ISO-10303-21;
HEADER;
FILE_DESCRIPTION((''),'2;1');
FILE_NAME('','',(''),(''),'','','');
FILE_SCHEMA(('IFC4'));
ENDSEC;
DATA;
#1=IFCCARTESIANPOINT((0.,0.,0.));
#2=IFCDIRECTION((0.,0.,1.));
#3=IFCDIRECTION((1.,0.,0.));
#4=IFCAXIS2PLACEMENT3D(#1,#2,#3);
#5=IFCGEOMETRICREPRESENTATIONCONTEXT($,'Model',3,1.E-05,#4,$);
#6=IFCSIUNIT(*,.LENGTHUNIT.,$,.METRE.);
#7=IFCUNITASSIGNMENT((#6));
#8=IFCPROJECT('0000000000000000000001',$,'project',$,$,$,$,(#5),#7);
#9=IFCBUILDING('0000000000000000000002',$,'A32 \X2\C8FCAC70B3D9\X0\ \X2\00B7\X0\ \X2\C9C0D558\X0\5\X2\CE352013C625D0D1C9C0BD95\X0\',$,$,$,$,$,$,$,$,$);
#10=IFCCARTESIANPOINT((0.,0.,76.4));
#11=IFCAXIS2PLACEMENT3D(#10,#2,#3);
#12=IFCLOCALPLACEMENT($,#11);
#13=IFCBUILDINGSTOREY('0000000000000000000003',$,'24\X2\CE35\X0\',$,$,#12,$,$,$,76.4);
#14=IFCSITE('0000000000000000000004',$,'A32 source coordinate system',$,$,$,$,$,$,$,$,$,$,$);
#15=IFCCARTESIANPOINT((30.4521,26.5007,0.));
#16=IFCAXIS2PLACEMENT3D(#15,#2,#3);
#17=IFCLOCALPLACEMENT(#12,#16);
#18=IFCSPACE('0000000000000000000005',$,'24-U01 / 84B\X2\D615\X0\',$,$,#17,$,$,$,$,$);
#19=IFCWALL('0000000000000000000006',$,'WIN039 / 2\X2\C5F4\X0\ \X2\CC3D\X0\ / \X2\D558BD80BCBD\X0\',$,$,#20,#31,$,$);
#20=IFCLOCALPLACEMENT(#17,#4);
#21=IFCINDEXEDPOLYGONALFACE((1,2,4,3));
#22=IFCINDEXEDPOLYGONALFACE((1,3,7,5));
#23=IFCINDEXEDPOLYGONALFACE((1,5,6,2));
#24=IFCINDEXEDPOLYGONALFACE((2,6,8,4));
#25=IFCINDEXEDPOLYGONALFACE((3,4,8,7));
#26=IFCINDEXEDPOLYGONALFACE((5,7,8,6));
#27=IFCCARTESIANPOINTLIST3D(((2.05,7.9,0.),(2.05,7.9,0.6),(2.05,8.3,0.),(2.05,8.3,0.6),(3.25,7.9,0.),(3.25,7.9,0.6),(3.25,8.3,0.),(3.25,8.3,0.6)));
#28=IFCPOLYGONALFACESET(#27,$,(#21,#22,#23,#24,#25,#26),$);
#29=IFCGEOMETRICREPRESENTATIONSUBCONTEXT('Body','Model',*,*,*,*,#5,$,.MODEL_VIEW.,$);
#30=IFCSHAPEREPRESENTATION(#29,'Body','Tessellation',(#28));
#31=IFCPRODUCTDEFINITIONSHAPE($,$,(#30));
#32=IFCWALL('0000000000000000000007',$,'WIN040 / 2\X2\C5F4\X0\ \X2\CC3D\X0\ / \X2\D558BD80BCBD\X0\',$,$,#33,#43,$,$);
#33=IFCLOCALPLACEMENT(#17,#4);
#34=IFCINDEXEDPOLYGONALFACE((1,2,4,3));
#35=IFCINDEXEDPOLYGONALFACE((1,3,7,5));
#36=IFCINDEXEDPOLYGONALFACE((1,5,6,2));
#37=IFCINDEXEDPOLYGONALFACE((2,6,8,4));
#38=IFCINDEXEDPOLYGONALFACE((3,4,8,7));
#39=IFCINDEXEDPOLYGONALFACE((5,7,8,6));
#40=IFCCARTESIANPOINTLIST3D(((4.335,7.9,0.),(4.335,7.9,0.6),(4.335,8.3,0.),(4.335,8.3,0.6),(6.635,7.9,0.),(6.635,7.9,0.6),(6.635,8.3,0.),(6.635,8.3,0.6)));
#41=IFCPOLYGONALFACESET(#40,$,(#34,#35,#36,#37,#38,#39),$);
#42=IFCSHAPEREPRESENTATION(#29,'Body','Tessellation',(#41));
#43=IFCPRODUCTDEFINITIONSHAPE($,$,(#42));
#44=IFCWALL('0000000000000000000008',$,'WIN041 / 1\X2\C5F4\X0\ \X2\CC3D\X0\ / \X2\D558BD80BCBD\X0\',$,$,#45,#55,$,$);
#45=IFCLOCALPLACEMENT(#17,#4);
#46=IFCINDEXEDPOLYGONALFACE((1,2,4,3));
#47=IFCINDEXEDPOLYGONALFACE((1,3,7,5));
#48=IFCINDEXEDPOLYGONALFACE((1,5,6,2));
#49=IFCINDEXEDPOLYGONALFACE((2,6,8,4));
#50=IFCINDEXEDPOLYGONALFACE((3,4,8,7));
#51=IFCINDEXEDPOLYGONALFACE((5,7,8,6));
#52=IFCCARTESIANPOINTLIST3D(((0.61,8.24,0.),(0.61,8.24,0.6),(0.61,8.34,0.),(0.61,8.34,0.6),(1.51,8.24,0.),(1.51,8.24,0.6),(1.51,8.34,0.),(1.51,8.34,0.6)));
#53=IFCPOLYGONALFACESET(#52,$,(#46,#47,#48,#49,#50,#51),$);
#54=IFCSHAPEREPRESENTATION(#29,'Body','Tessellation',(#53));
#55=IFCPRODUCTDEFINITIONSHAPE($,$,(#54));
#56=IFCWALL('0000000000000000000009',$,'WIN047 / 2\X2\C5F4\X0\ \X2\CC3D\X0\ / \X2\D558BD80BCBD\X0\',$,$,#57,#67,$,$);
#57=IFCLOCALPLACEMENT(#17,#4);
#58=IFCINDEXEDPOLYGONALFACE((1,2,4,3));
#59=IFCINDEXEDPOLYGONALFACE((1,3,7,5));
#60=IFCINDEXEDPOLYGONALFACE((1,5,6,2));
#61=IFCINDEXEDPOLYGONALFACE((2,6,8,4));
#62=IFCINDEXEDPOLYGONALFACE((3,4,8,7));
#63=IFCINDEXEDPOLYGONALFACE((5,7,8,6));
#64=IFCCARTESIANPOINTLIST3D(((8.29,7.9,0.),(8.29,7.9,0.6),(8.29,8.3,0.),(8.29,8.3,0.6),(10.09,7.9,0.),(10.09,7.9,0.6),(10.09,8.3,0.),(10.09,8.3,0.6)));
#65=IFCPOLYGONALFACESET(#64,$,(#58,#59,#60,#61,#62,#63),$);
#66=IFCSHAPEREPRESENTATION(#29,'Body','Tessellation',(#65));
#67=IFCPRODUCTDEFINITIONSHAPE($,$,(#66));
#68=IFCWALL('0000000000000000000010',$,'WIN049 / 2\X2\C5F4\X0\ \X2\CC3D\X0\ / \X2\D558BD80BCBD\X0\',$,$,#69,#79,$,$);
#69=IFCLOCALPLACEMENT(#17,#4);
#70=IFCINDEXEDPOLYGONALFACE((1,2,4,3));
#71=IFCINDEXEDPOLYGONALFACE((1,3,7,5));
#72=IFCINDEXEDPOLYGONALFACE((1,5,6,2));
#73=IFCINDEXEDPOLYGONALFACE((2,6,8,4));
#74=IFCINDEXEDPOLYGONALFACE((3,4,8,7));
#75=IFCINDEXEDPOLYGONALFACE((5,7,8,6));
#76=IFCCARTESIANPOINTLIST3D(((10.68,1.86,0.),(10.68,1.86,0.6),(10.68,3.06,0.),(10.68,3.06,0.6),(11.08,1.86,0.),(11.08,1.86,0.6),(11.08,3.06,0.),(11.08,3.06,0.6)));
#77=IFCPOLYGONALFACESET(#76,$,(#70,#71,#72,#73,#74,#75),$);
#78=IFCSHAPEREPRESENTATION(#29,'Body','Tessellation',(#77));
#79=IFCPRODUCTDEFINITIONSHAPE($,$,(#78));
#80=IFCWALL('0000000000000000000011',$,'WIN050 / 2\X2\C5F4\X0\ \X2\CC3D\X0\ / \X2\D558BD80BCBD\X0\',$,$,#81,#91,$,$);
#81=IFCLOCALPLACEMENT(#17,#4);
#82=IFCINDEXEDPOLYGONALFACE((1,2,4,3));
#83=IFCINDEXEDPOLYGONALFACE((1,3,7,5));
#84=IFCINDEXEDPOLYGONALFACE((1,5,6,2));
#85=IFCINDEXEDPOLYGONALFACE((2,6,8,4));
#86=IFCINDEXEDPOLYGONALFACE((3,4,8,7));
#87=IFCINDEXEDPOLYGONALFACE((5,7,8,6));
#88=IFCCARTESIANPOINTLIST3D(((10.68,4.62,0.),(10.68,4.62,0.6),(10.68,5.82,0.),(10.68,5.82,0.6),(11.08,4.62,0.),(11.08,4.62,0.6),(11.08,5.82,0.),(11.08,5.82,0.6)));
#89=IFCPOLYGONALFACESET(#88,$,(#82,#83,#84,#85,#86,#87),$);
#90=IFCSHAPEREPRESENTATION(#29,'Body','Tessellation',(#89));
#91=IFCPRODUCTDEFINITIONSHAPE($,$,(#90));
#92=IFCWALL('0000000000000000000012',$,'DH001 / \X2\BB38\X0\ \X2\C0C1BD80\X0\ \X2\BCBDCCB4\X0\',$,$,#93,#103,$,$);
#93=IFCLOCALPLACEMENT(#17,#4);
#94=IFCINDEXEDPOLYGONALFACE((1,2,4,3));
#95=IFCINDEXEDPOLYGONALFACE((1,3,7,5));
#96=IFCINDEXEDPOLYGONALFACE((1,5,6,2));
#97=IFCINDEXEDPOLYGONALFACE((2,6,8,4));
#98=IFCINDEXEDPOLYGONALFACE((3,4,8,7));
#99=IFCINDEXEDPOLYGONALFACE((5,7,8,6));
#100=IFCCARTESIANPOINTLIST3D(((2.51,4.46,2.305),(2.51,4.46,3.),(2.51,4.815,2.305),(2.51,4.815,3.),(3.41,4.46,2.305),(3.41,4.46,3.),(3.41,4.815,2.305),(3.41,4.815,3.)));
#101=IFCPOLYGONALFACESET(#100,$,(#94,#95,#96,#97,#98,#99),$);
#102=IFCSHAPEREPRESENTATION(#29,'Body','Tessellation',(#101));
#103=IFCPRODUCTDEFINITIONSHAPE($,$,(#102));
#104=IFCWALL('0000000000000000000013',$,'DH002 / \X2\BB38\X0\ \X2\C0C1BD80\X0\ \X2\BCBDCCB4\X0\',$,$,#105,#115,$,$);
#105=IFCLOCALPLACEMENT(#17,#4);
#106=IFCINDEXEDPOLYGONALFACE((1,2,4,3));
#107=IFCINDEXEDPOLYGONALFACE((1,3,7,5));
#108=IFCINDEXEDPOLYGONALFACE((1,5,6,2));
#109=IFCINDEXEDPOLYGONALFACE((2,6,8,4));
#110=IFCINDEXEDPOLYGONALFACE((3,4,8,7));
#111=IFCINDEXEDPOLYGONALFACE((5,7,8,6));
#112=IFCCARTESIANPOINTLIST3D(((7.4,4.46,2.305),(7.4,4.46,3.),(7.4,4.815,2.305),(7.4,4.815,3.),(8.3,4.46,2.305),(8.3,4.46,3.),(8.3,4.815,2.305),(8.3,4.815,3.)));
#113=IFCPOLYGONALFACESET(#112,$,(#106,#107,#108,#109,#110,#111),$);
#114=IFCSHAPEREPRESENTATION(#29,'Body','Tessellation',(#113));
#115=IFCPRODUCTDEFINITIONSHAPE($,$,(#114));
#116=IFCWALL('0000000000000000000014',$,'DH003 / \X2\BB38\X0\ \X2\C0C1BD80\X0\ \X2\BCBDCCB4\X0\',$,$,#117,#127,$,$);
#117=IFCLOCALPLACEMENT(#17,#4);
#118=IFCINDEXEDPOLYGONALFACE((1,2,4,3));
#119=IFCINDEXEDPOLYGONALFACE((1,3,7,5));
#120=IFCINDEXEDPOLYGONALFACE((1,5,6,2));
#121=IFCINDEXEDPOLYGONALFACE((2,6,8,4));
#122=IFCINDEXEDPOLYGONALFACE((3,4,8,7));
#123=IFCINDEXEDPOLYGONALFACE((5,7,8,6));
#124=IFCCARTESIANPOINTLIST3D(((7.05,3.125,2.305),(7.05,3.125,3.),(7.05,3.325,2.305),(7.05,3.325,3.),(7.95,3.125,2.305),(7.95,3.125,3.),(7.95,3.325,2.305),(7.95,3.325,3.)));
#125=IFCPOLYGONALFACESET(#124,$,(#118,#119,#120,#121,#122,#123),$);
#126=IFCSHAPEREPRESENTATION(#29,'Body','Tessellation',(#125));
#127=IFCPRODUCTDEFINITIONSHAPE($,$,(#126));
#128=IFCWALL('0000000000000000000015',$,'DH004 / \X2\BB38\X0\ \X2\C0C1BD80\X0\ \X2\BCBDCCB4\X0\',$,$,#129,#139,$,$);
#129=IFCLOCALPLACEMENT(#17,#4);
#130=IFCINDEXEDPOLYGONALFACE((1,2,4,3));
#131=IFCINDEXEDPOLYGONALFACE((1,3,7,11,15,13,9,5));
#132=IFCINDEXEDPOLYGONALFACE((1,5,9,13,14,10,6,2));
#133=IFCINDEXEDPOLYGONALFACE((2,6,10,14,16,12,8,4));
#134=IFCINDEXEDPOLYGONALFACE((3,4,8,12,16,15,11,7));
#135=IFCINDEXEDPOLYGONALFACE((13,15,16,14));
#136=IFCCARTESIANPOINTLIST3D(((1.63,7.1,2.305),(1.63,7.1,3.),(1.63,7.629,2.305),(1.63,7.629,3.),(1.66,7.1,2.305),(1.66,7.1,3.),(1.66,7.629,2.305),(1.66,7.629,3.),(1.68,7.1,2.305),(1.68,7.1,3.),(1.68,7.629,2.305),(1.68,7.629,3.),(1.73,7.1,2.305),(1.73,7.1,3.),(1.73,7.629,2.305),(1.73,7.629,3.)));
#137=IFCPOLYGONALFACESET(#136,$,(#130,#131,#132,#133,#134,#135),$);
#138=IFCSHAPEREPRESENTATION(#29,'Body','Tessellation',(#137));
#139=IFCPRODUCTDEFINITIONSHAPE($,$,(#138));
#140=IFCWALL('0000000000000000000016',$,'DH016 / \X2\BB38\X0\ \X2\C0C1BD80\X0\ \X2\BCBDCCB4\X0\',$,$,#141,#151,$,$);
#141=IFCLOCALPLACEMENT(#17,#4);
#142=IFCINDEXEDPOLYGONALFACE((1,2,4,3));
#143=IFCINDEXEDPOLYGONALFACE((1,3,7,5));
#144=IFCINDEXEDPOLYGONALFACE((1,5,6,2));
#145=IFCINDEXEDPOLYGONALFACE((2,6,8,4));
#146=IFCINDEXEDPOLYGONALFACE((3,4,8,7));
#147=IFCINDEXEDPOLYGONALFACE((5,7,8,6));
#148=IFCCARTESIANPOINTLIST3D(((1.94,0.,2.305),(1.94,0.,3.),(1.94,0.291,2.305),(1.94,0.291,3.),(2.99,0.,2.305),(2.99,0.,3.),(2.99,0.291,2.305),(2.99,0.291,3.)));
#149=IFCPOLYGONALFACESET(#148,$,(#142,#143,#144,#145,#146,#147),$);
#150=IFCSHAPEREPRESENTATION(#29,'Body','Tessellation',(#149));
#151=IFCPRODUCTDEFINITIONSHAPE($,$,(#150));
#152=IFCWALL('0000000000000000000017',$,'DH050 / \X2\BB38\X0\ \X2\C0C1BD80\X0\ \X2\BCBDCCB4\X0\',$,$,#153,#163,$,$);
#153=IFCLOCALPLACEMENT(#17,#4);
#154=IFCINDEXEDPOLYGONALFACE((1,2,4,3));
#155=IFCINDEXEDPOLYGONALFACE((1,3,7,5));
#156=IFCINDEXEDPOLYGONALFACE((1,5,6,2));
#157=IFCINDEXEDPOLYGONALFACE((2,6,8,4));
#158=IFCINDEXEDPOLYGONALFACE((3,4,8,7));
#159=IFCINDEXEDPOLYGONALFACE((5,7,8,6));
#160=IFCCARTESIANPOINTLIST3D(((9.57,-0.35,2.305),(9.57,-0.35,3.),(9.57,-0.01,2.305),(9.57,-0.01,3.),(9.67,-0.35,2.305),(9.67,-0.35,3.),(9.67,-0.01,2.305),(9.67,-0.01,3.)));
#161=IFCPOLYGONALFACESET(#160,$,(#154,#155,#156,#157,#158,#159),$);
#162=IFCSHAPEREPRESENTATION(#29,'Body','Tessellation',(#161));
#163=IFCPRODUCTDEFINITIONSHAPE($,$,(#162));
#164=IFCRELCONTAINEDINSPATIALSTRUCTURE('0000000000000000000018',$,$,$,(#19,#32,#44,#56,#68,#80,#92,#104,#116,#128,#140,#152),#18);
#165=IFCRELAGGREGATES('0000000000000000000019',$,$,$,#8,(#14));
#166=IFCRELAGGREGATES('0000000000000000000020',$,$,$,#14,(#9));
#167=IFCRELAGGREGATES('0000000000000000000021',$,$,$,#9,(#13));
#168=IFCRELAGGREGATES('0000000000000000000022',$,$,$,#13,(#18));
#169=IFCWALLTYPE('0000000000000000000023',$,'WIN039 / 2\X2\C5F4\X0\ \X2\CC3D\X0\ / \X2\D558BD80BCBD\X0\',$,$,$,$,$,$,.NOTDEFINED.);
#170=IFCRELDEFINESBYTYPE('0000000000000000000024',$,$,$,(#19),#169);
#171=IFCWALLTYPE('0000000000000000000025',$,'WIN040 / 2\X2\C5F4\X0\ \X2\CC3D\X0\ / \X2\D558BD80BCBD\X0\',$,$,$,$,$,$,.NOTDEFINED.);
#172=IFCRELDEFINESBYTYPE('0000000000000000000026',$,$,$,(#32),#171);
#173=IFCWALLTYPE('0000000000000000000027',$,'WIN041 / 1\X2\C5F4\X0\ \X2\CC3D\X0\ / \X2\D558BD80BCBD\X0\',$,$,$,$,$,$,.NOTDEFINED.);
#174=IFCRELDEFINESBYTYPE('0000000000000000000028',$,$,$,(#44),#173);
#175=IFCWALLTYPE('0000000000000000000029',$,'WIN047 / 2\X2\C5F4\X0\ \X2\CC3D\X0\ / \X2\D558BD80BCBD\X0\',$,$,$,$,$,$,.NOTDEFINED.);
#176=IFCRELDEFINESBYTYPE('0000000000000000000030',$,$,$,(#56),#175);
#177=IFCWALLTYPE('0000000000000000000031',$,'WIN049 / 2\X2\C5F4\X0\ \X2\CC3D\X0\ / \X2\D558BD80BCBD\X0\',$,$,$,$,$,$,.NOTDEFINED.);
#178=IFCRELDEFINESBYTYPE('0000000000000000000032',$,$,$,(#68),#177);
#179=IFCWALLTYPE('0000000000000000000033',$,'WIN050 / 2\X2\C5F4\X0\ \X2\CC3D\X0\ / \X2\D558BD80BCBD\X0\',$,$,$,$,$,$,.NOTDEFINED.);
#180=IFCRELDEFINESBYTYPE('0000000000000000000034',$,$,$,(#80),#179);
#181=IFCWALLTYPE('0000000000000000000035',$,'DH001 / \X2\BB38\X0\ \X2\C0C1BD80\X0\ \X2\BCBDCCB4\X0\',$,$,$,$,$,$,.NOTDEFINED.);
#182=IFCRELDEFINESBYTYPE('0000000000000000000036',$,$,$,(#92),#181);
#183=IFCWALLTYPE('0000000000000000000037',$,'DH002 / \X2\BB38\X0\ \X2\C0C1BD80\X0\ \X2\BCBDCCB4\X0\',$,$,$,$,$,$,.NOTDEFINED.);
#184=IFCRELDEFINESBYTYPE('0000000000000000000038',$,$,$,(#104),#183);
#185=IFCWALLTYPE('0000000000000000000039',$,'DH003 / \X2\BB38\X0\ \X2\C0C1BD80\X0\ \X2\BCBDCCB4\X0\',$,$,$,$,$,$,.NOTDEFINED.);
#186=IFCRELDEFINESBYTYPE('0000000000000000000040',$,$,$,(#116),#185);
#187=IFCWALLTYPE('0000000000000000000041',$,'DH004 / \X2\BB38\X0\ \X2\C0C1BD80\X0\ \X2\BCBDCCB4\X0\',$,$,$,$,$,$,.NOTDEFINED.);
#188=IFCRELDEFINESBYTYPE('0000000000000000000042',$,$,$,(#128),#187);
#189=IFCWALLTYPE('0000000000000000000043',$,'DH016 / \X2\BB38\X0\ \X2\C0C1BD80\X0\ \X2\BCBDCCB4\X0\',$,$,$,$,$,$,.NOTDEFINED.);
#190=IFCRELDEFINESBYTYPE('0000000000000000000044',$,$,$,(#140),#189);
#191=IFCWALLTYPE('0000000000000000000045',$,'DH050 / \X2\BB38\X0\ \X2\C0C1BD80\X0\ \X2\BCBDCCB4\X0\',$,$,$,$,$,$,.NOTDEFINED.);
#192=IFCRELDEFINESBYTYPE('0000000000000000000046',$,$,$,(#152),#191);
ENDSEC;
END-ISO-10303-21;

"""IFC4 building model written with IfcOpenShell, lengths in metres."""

from ifc_helpers import new_model, si_unit, frame, origin, origin_with_axes, place, context, subcontext, project, spatial, polyline, outline, extrude, source, transform, mapped, type_object, type_shapes, element, save


model = new_model("IFC4")

# Units and contexts
model_context = context("Model", 3, precision=1e-05, world=origin_with_axes())
body_context = subcontext(model_context, "Body", "Model", "MODEL_VIEW")
ifc_project = project(units=[si_unit("LENGTHUNIT", "METRE")], contexts=[model_context])

# Site, building, storey, space
site = spatial("IfcSite", under=ifc_project, Name="A32 source coordinate system")
building = spatial("IfcBuilding", under=site, Name="A32 주거동 · 지하5층–옥탑지붕")
storey_placement = place(None, frame((0.0, 0.0, 76.4), z_axis=(0.0, 0.0, 1.0), x_axis=(1.0, 0.0, 0.0)))
storey = spatial("IfcBuildingStorey", under=building, at=storey_placement, Name="24층", Elevation=76.4)
space_placement = place(storey_placement, frame((30.4521, 26.5007, 0.0), z_axis=(0.0, 0.0, 1.0), x_axis=(1.0, 0.0, 0.0)))
space = spatial("IfcSpace", under=storey, at=space_placement, Name="24-U01 / 84B형")

# Walls
wall_type_1 = type_object("IfcWallType", Name="WIN039 / 2열 창 / 하부벽", PredefinedType="NOTDEFINED")
shared_shape_1 = source(origin(), body_context, "Body", "SweptSolid", [
    extrude(outline(polyline([(2.05, 8.3), (3.25, 8.3), (3.25, 7.9), (2.05, 7.9), (2.05, 8.3)])), origin(), (0.0, 0.0, 1.0), 0.6),
])
type_shapes(wall_type_1, [shared_shape_1])
wall_1_placement = place(space_placement, origin_with_axes())
element("IfcWall", 1, at=wall_1_placement, inside=space, type_object=wall_type_1, Name="WIN039 / 2열 창 / 하부벽", context=body_context, shape_type="MappedRepresentation", body=[
    mapped(shared_shape_1, transform((0.0, 0.0, 0.0), scale=1.0)),
])
wall_type_2 = type_object("IfcWallType", Name="WIN040 / 2열 창 / 하부벽", PredefinedType="NOTDEFINED")
shared_shape_2 = source(origin(), body_context, "Body", "SweptSolid", [
    extrude(outline(polyline([(4.335, 8.3), (6.635, 8.3), (6.635, 7.9), (4.335, 7.9), (4.335, 8.3)])), origin(), (0.0, 0.0, 1.0), 0.6),
])
type_shapes(wall_type_2, [shared_shape_2])
wall_2_placement = place(space_placement, origin_with_axes())
element("IfcWall", 2, at=wall_2_placement, inside=space, type_object=wall_type_2, Name="WIN040 / 2열 창 / 하부벽", context=body_context, shape_type="MappedRepresentation", body=[
    mapped(shared_shape_2, transform((0.0, 0.0, 0.0), scale=1.0)),
])
wall_type_3 = type_object("IfcWallType", Name="WIN041 / 1열 창 / 하부벽", PredefinedType="NOTDEFINED")
shared_shape_3 = source(origin(), body_context, "Body", "SweptSolid", [
    extrude(outline(polyline([(0.61, 8.34), (1.51, 8.34), (1.51, 8.24), (0.61, 8.24), (0.61, 8.34)])), origin(), (0.0, 0.0, 1.0), 0.6),
])
type_shapes(wall_type_3, [shared_shape_3])
wall_3_placement = place(space_placement, origin_with_axes())
element("IfcWall", 3, at=wall_3_placement, inside=space, type_object=wall_type_3, Name="WIN041 / 1열 창 / 하부벽", context=body_context, shape_type="MappedRepresentation", body=[
    mapped(shared_shape_3, transform((0.0, 0.0, 0.0), scale=1.0)),
])
wall_type_4 = type_object("IfcWallType", Name="WIN047 / 2열 창 / 하부벽", PredefinedType="NOTDEFINED")
shared_shape_4 = source(origin(), body_context, "Body", "SweptSolid", [
    extrude(outline(polyline([(8.29, 8.3), (10.09, 8.3), (10.09, 7.9), (8.29, 7.9), (8.29, 8.3)])), origin(), (0.0, 0.0, 1.0), 0.6),
])
type_shapes(wall_type_4, [shared_shape_4])
wall_4_placement = place(space_placement, origin_with_axes())
element("IfcWall", 4, at=wall_4_placement, inside=space, type_object=wall_type_4, Name="WIN047 / 2열 창 / 하부벽", context=body_context, shape_type="MappedRepresentation", body=[
    mapped(shared_shape_4, transform((0.0, 0.0, 0.0), scale=1.0)),
])
wall_type_5 = type_object("IfcWallType", Name="WIN049 / 2열 창 / 하부벽", PredefinedType="NOTDEFINED")
shared_shape_5 = source(origin(), body_context, "Body", "SweptSolid", [
    extrude(outline(polyline([(10.68, 3.06), (11.08, 3.06), (11.08, 1.86), (10.68, 1.86), (10.68, 3.06)])), origin(), (0.0, 0.0, 1.0), 0.6),
])
type_shapes(wall_type_5, [shared_shape_5])
wall_5_placement = place(space_placement, origin_with_axes())
element("IfcWall", 5, at=wall_5_placement, inside=space, type_object=wall_type_5, Name="WIN049 / 2열 창 / 하부벽", context=body_context, shape_type="MappedRepresentation", body=[
    mapped(shared_shape_5, transform((0.0, 0.0, 0.0), scale=1.0)),
])
wall_type_6 = type_object("IfcWallType", Name="WIN050 / 2열 창 / 하부벽", PredefinedType="NOTDEFINED")
shared_shape_6 = source(origin(), body_context, "Body", "SweptSolid", [
    extrude(outline(polyline([(10.68, 5.82), (11.08, 5.82), (11.08, 4.62), (10.68, 4.62), (10.68, 5.82)])), origin(), (0.0, 0.0, 1.0), 0.6),
])
type_shapes(wall_type_6, [shared_shape_6])
wall_6_placement = place(space_placement, origin_with_axes())
element("IfcWall", 6, at=wall_6_placement, inside=space, type_object=wall_type_6, Name="WIN050 / 2열 창 / 하부벽", context=body_context, shape_type="MappedRepresentation", body=[
    mapped(shared_shape_6, transform((0.0, 0.0, 0.0), scale=1.0)),
])
wall_type_7 = type_object("IfcWallType", Name="DH001 / 문 상부 벽체", PredefinedType="NOTDEFINED")
shared_shape_7 = source(origin(), body_context, "Body", "SweptSolid", [
    extrude(outline(polyline([(3.41, 4.815), (3.41, 4.46), (2.51, 4.46), (2.51, 4.815), (3.41, 4.815)])), frame((0.0, 0.0, 2.305)), (0.0, 0.0, 1.0), 0.695),
])
type_shapes(wall_type_7, [shared_shape_7])
wall_7_placement = place(space_placement, origin_with_axes())
element("IfcWall", 7, at=wall_7_placement, inside=space, type_object=wall_type_7, Name="DH001 / 문 상부 벽체", context=body_context, shape_type="MappedRepresentation", body=[
    mapped(shared_shape_7, transform((0.0, 0.0, 0.0), scale=1.0)),
])
wall_type_8 = type_object("IfcWallType", Name="DH002 / 문 상부 벽체", PredefinedType="NOTDEFINED")
shared_shape_8 = source(origin(), body_context, "Body", "SweptSolid", [
    extrude(outline(polyline([(8.3, 4.815), (8.3, 4.46), (7.4, 4.46), (7.4, 4.815), (8.3, 4.815)])), frame((0.0, 0.0, 2.305)), (0.0, 0.0, 1.0), 0.695),
])
type_shapes(wall_type_8, [shared_shape_8])
wall_8_placement = place(space_placement, origin_with_axes())
element("IfcWall", 8, at=wall_8_placement, inside=space, type_object=wall_type_8, Name="DH002 / 문 상부 벽체", context=body_context, shape_type="MappedRepresentation", body=[
    mapped(shared_shape_8, transform((0.0, 0.0, 0.0), scale=1.0)),
])
wall_type_9 = type_object("IfcWallType", Name="DH003 / 문 상부 벽체", PredefinedType="NOTDEFINED")
shared_shape_9 = source(origin(), body_context, "Body", "SweptSolid", [
    extrude(outline(polyline([(7.95, 3.325), (7.95, 3.125), (7.05, 3.125), (7.05, 3.325), (7.95, 3.325)])), frame((0.0, 0.0, 2.305)), (0.0, 0.0, 1.0), 0.695),
])
type_shapes(wall_type_9, [shared_shape_9])
wall_9_placement = place(space_placement, origin_with_axes())
element("IfcWall", 9, at=wall_9_placement, inside=space, type_object=wall_type_9, Name="DH003 / 문 상부 벽체", context=body_context, shape_type="MappedRepresentation", body=[
    mapped(shared_shape_9, transform((0.0, 0.0, 0.0), scale=1.0)),
])
wall_type_10 = type_object("IfcWallType", Name="DH004 / 문 상부 벽체", PredefinedType="NOTDEFINED")
shared_shape_10 = source(origin(), body_context, "Body", "SweptSolid", [
    extrude(outline(polyline([(1.66, 7.1), (1.63, 7.1), (1.63, 7.629), (1.66, 7.629), (1.68, 7.629), (1.73, 7.629), (1.73, 7.1), (1.68, 7.1), (1.66, 7.1)])), frame((0.0, 0.0, 2.305)), (0.0, 0.0, 1.0), 0.695),
])
type_shapes(wall_type_10, [shared_shape_10])
wall_10_placement = place(space_placement, origin_with_axes())
element("IfcWall", 10, at=wall_10_placement, inside=space, type_object=wall_type_10, Name="DH004 / 문 상부 벽체", context=body_context, shape_type="MappedRepresentation", body=[
    mapped(shared_shape_10, transform((0.0, 0.0, 0.0), scale=1.0)),
])
wall_type_11 = type_object("IfcWallType", Name="DH016 / 문 상부 벽체", PredefinedType="NOTDEFINED")
shared_shape_11 = source(origin(), body_context, "Body", "SweptSolid", [
    extrude(outline(polyline([(2.99, 0.291), (2.99, 0.0), (1.94, 0.0), (1.94, 0.291), (2.99, 0.291)])), frame((0.0, 0.0, 2.305)), (0.0, 0.0, 1.0), 0.695),
])
type_shapes(wall_type_11, [shared_shape_11])
wall_11_placement = place(space_placement, origin_with_axes())
element("IfcWall", 11, at=wall_11_placement, inside=space, type_object=wall_type_11, Name="DH016 / 문 상부 벽체", context=body_context, shape_type="MappedRepresentation", body=[
    mapped(shared_shape_11, transform((0.0, 0.0, 0.0), scale=1.0)),
])
wall_type_12 = type_object("IfcWallType", Name="DH050 / 문 상부 벽체", PredefinedType="NOTDEFINED")
shared_shape_12 = source(origin(), body_context, "Body", "SweptSolid", [
    extrude(outline(polyline([(9.67, -0.01), (9.67, -0.35), (9.57, -0.35), (9.57, -0.01), (9.67, -0.01)])), frame((0.0, 0.0, 2.305)), (0.0, 0.0, 1.0), 0.695),
])
type_shapes(wall_type_12, [shared_shape_12])
wall_12_placement = place(space_placement, origin_with_axes())
element("IfcWall", 12, at=wall_12_placement, inside=space, type_object=wall_type_12, Name="DH050 / 문 상부 벽체", context=body_context, shape_type="MappedRepresentation", body=[
    mapped(shared_shape_12, transform((0.0, 0.0, 0.0), scale=1.0)),
])

save(model, "model.ifc")
